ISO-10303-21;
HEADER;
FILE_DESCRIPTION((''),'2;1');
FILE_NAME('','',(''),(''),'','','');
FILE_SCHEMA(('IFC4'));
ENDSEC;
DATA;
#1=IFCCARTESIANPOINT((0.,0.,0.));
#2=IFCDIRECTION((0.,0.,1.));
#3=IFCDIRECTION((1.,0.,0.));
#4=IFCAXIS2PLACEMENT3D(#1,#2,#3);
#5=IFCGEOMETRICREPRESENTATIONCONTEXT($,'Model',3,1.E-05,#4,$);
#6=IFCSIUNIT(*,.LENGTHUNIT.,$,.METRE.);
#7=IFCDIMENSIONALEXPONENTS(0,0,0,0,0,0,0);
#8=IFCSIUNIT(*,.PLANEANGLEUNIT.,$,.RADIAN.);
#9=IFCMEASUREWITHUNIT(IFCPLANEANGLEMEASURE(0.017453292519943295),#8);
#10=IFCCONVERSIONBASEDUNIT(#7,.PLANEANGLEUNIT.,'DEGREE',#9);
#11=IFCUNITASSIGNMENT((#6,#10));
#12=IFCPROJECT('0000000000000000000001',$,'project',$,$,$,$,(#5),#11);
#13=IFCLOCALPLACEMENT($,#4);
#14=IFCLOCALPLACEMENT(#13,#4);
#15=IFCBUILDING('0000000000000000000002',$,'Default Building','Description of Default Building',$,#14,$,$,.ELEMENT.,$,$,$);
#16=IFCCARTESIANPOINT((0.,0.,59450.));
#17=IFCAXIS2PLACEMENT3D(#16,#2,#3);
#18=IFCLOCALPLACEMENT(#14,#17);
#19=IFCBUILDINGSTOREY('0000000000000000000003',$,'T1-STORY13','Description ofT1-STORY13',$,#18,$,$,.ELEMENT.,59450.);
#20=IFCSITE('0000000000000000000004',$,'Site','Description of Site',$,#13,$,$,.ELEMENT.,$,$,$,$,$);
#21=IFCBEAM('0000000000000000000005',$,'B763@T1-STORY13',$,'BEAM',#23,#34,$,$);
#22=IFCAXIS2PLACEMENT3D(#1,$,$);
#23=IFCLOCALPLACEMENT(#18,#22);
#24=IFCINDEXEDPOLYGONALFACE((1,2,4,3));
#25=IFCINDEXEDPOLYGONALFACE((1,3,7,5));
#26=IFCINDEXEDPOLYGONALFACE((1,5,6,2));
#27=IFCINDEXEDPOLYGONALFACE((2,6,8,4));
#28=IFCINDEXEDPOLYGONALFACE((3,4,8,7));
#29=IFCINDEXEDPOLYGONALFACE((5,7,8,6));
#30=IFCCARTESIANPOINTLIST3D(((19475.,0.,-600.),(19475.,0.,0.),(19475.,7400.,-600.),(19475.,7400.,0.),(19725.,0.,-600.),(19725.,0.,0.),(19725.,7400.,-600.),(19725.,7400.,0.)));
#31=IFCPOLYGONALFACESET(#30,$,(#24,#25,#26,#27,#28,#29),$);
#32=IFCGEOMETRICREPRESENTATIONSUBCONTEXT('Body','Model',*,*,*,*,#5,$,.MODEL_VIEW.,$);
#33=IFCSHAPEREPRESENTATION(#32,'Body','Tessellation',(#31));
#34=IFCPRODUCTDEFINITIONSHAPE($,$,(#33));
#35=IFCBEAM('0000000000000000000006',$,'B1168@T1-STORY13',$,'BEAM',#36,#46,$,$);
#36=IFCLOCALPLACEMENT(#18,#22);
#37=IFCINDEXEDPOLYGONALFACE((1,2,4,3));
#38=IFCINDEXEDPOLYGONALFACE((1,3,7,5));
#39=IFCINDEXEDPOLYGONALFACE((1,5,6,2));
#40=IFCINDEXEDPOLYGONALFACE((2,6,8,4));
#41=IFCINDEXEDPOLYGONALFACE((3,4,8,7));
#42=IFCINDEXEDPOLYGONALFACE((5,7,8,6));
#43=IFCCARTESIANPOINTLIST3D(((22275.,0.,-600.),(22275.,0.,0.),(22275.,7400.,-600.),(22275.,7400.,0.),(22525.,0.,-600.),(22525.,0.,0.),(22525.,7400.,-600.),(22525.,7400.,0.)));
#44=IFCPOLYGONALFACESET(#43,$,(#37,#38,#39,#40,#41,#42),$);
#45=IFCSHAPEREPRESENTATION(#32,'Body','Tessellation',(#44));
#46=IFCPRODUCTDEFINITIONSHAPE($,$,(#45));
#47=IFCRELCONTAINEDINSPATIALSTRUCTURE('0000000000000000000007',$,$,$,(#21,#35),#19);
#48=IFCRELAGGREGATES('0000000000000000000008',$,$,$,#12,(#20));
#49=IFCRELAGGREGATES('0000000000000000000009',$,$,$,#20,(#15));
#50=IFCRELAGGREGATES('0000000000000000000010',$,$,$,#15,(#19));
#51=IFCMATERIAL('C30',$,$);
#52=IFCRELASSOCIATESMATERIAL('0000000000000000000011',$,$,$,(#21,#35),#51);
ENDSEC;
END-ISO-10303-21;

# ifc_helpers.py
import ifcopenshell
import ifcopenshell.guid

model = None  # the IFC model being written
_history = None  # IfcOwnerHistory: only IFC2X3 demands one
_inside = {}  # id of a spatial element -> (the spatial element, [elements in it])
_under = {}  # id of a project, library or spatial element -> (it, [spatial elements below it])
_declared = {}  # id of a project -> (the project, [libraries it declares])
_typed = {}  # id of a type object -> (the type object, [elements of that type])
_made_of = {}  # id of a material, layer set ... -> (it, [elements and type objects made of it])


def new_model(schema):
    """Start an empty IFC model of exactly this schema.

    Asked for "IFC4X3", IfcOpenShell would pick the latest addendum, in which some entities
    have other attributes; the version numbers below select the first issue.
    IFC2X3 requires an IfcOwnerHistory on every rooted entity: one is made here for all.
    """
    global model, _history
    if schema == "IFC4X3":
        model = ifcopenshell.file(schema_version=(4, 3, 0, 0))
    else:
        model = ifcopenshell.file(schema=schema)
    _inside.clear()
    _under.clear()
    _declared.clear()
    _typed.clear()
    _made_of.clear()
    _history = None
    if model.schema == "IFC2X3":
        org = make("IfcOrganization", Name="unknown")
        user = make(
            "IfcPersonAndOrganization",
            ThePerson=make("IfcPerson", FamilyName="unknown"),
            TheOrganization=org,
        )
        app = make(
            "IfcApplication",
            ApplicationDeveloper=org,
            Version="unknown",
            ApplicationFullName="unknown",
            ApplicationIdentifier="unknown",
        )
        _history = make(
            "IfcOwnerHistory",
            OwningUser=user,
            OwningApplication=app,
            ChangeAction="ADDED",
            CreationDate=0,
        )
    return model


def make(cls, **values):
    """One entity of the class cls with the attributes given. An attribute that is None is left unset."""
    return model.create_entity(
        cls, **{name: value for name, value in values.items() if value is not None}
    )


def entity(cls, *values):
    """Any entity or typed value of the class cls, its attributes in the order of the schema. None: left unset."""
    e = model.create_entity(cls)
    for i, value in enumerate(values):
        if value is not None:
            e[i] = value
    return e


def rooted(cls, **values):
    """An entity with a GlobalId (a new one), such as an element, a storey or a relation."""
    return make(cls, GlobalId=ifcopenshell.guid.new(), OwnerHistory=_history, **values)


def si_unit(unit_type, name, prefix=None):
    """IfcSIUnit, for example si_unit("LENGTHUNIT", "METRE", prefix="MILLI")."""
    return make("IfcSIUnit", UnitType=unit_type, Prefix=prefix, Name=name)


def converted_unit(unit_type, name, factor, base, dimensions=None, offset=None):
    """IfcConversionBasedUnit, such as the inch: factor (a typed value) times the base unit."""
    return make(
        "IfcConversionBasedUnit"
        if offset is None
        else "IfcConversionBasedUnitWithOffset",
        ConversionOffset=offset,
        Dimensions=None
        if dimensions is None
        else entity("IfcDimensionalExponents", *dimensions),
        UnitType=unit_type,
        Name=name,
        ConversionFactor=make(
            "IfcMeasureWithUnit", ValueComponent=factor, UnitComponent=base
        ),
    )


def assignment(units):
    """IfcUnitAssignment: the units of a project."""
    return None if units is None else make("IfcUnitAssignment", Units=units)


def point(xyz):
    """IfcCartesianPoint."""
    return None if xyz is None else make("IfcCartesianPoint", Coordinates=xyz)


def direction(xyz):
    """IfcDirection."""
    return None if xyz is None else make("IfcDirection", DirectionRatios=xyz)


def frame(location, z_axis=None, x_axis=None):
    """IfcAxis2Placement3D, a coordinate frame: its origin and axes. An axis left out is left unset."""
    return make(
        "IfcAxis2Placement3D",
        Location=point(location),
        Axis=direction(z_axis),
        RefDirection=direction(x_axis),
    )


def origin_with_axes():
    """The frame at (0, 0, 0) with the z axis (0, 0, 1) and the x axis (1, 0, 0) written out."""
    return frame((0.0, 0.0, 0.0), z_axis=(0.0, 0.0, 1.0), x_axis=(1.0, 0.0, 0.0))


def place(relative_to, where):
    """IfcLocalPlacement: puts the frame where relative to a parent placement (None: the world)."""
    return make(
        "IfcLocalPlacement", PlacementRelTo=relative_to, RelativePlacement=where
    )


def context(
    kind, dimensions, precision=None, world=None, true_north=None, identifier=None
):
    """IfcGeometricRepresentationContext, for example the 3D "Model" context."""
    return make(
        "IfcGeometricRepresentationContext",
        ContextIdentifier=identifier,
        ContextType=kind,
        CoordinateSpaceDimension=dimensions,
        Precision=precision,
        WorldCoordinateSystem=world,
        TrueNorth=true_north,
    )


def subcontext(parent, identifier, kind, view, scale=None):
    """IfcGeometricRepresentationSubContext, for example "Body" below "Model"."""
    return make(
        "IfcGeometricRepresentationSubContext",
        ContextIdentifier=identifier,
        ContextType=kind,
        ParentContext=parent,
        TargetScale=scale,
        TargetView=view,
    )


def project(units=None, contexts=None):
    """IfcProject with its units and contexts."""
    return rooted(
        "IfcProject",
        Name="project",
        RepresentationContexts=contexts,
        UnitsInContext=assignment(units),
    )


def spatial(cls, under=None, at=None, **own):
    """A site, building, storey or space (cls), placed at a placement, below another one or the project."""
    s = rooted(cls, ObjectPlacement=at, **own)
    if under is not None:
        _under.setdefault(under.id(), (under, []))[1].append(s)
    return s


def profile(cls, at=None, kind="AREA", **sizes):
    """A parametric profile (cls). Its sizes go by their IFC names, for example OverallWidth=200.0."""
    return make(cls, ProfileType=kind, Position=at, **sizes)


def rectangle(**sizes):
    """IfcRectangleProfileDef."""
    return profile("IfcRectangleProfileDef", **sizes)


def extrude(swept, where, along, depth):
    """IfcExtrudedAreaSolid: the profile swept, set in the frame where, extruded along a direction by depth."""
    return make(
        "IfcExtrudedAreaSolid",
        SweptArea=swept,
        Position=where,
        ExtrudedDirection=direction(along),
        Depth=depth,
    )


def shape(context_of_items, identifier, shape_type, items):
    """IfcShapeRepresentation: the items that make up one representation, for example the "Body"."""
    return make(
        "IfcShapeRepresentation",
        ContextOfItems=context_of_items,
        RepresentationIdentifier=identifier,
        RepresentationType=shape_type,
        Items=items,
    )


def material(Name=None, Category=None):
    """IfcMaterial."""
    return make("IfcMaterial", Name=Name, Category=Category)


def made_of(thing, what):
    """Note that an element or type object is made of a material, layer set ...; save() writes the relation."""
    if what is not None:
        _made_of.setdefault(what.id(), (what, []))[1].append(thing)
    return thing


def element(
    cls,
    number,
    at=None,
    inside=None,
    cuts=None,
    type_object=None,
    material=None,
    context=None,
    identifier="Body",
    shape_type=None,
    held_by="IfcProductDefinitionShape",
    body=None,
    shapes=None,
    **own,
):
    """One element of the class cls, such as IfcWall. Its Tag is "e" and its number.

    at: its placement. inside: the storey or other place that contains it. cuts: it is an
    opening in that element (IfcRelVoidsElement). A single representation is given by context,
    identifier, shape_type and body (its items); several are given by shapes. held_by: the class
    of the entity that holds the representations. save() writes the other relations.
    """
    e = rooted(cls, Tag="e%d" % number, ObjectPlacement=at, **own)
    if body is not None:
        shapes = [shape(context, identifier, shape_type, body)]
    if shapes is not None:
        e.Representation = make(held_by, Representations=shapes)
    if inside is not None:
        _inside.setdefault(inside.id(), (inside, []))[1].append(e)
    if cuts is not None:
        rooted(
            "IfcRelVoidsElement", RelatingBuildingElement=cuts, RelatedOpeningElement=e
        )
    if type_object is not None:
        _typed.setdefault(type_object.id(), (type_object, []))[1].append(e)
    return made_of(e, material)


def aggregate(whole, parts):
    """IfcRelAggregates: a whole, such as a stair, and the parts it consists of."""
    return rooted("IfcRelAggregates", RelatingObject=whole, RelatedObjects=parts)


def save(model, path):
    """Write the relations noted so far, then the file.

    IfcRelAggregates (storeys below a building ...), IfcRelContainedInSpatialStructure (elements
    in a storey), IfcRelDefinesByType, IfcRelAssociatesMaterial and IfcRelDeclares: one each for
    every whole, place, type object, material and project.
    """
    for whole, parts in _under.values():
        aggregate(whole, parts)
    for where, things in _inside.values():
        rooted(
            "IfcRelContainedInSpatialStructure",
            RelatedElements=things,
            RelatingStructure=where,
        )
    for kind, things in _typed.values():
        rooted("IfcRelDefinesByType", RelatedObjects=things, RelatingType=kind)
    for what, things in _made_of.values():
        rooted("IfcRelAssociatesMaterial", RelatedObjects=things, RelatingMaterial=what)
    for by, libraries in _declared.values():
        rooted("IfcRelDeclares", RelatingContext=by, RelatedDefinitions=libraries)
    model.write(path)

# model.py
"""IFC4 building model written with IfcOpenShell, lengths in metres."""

from ifc_helpers import new_model, entity, si_unit, converted_unit, frame, origin_with_axes, place, context, subcontext, project, spatial, rectangle, extrude, material, element, save


model = new_model("IFC4")

# Units and contexts
model_context = context("Model", 3, precision=1e-05, world=origin_with_axes())
body_context = subcontext(model_context, "Body", "Model", "MODEL_VIEW")
ifc_project = project(units=[si_unit("LENGTHUNIT", "METRE"), converted_unit("PLANEANGLEUNIT", "DEGREE", entity("IfcPlaneAngleMeasure", 0.017453292519943295), si_unit("PLANEANGLEUNIT", "RADIAN"), dimensions=[0, 0, 0, 0, 0, 0, 0])], contexts=[model_context])

# Site, building, storey
site_placement = place(None, origin_with_axes())
site = spatial("IfcSite", under=ifc_project, at=site_placement, Name="Site", Description="Description of Site", CompositionType="ELEMENT")
building_placement = place(site_placement, origin_with_axes())
building = spatial("IfcBuilding", under=site, at=building_placement, Name="Default Building", Description="Description of Default Building", CompositionType="ELEMENT")
storey_placement = place(building_placement, frame((0.0, 0.0, 59450.0), z_axis=(0.0, 0.0, 1.0), x_axis=(1.0, 0.0, 0.0)))
storey = spatial("IfcBuildingStorey", under=building, at=storey_placement, Name="T1-STORY13", Description="Description ofT1-STORY13", CompositionType="ELEMENT", Elevation=59450.0)

# Beams
ifc_material_1 = material(Name="C30")
for number, where, z_axis, x_axis, name in (
    (1, (19600.0, 0.0, -300.0), (0.0, 1.0, 0.0), (-1.0, 0.0, 0.0), "B763@T1-STORY13"),
    (2, (22400.0, 0.0, -300.0), (0.0, 1.0, 0.0), (-1.0, 0.0, 0.0), "B1168@T1-STORY13"),
):
    element("IfcBeam", number, at=place(storey_placement, frame(where, z_axis=z_axis, x_axis=x_axis)), inside=storey, material=ifc_material_1, Name=name, ObjectType="BEAM", context=body_context, shape_type="SweptSolid", body=[
        extrude(rectangle(XDim=250.0, YDim=600.0), origin_with_axes(), (0.0, 0.0, 1.0), 7400.0),
    ])

save(model, "model.ifc")
